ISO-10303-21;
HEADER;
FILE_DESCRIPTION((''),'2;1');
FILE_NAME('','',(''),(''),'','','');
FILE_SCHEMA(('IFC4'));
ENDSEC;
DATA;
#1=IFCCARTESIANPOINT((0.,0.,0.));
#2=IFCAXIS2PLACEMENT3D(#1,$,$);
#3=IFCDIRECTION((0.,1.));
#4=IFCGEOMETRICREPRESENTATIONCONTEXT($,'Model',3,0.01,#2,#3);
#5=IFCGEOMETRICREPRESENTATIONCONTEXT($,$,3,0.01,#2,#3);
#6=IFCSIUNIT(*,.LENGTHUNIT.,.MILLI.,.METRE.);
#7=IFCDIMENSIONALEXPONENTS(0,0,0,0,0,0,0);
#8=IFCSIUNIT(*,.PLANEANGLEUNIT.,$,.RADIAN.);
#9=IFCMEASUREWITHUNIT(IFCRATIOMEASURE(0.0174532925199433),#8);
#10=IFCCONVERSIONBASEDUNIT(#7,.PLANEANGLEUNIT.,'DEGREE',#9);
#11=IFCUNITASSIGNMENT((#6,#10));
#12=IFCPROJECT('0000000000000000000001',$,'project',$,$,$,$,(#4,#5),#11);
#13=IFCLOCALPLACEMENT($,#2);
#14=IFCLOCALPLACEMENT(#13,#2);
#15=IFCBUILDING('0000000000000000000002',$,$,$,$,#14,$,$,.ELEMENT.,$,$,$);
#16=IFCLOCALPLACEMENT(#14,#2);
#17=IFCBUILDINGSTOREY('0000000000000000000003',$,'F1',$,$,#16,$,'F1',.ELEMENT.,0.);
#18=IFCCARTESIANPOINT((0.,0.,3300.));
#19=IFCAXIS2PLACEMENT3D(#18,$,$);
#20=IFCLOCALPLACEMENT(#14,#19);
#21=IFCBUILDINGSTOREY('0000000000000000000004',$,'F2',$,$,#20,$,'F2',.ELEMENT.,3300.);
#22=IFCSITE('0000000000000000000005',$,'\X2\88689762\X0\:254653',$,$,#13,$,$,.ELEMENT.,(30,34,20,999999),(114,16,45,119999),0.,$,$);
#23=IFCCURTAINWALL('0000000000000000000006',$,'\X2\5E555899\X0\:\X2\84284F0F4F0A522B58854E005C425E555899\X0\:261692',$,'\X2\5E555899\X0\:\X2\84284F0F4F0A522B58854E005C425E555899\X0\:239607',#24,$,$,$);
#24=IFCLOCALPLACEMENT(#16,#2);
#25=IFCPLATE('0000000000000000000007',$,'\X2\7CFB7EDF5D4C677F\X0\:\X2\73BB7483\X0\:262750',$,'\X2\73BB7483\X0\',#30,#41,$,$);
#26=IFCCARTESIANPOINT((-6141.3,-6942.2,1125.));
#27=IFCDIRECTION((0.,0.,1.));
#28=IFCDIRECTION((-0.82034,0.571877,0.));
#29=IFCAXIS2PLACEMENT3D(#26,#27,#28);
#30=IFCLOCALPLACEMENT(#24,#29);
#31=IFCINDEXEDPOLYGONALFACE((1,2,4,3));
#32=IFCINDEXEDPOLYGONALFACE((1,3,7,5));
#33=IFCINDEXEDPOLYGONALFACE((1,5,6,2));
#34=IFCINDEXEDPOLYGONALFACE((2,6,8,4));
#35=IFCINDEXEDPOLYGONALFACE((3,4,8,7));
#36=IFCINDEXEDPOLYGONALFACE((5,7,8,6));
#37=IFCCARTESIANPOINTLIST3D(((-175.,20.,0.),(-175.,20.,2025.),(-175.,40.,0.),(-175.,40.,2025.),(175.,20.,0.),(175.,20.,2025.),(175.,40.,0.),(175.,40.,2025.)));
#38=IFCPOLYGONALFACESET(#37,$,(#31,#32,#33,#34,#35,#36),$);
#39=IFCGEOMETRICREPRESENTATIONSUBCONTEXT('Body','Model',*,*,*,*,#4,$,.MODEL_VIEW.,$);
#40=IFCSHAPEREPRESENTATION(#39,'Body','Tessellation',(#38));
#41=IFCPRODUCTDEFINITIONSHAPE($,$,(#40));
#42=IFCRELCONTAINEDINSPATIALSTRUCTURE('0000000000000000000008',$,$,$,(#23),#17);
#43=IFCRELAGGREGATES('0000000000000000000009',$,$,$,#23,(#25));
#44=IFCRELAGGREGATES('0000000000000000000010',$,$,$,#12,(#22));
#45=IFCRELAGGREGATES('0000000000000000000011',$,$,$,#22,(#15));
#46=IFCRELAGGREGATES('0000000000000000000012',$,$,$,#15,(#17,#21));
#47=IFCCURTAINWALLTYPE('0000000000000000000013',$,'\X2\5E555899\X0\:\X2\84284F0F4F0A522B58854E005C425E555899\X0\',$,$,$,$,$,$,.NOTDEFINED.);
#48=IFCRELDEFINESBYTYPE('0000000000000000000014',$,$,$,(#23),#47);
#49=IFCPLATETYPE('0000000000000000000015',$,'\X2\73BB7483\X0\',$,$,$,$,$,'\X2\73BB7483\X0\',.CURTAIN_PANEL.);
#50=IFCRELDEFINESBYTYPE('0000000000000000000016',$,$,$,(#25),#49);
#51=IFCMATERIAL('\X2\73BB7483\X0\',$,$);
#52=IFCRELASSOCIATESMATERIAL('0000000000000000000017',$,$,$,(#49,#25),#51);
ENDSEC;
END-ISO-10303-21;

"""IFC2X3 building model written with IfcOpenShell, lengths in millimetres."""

from ifc_helpers import new_model, entity, si_unit, converted_unit, direction, frame, frame_2d, origin, place, context, subcontext, project, spatial, rectangle, extrude, source, transform, mapped, material, type_object, type_shapes, element, aggregate, save


model = new_model("IFC2X3")

# Units and contexts
model_context = context("Model", 3, precision=0.01, world=origin(), true_north=direction((0.0, 1.0)))
context_of_model = context(None, 3, precision=0.01, world=origin(), true_north=direction((0.0, 1.0)))
body_context = subcontext(model_context, "Body", "Model", "MODEL_VIEW")
ifc_project = project(units=[si_unit("LENGTHUNIT", "METRE", prefix="MILLI"), converted_unit("PLANEANGLEUNIT", "DEGREE", entity("IfcRatioMeasure", 0.0174532925199433), si_unit("PLANEANGLEUNIT", "RADIAN"), dimensions=[0, 0, 0, 0, 0, 0, 0])], contexts=[model_context, context_of_model])

# Site, building, storey
site_placement = place(None, origin())
site = spatial("IfcSite", under=ifc_project, at=site_placement, Name="表面:254653", CompositionType="ELEMENT", RefLatitude=(30, 34, 20, 999999), RefLongitude=(114, 16, 45, 119999), RefElevation=0.0)
building_placement = place(site_placement, origin())
building = spatial("IfcBuilding", under=site, at=building_placement, CompositionType="ELEMENT")
storey_1_placement = place(building_placement, origin())
storey_1 = spatial("IfcBuildingStorey", under=building, at=storey_1_placement, Name="F1", LongName="F1", CompositionType="ELEMENT", Elevation=0.0)

# Curtain wall, plate
curtain_wall_type = type_object("IfcCurtainWallType", Name="幕墙:萨伏伊别墅一层幕墙", PredefinedType="NOTDEFINED")
curtain_wall_placement = place(storey_1_placement, origin())
curtain_wall = element("IfcCurtainWall", 1, at=curtain_wall_placement, inside=storey_1, type_object=curtain_wall_type, Name="幕墙:萨伏伊别墅一层幕墙:261692", ObjectType="幕墙:萨伏伊别墅一层幕墙:239607")
ifc_material_1 = material(Name="玻璃")
plate_type_1 = type_object("IfcPlateType", Name="玻璃", ElementType="玻璃", PredefinedType="CURTAIN_PANEL", material=ifc_material_1)
shared_shape_1 = source(origin(), body_context, "Body", "SweptSolid", [
    extrude(rectangle(XDim=20.0, YDim=350.0, at=frame_2d((0.0, 0.0), x_axis=(1.0, 0.0))), frame((0.0, 30.0, 0.0), z_axis=(0.0, 0.0, 1.0), x_axis=(0.0, 1.0, 0.0)), (0.0, 0.0, 1.0), 2025.0),
])
type_shapes(plate_type_1, [shared_shape_1])
plate_1_placement = place(curtain_wall_placement, frame((-6141.3, -6942.2, 1125.0), z_axis=(0.0, 0.0, 1.0), x_axis=(-0.82034, 0.571877, 0.0)))
plate_1 = element("IfcPlate", 2, at=plate_1_placement, type_object=plate_type_1, material=ifc_material_1, Name="系统嵌板:玻璃:262750", ObjectType="玻璃", context=body_context, shape_type="MappedRepresentation", body=[
    mapped(shared_shape_1, transform((0.0, 0.0, 0.0), scale=1.0)),
])
aggregate(curtain_wall, [plate_1])

# Shared definitions
storey_2_placement = place(building_placement, frame((0.0, 0.0, 3300.0)))
storey_2 = spatial("IfcBuildingStorey", under=building, at=storey_2_placement, Name="F2", LongName="F2", CompositionType="ELEMENT", Elevation=3300.0)

save(model, "model.ifc")
